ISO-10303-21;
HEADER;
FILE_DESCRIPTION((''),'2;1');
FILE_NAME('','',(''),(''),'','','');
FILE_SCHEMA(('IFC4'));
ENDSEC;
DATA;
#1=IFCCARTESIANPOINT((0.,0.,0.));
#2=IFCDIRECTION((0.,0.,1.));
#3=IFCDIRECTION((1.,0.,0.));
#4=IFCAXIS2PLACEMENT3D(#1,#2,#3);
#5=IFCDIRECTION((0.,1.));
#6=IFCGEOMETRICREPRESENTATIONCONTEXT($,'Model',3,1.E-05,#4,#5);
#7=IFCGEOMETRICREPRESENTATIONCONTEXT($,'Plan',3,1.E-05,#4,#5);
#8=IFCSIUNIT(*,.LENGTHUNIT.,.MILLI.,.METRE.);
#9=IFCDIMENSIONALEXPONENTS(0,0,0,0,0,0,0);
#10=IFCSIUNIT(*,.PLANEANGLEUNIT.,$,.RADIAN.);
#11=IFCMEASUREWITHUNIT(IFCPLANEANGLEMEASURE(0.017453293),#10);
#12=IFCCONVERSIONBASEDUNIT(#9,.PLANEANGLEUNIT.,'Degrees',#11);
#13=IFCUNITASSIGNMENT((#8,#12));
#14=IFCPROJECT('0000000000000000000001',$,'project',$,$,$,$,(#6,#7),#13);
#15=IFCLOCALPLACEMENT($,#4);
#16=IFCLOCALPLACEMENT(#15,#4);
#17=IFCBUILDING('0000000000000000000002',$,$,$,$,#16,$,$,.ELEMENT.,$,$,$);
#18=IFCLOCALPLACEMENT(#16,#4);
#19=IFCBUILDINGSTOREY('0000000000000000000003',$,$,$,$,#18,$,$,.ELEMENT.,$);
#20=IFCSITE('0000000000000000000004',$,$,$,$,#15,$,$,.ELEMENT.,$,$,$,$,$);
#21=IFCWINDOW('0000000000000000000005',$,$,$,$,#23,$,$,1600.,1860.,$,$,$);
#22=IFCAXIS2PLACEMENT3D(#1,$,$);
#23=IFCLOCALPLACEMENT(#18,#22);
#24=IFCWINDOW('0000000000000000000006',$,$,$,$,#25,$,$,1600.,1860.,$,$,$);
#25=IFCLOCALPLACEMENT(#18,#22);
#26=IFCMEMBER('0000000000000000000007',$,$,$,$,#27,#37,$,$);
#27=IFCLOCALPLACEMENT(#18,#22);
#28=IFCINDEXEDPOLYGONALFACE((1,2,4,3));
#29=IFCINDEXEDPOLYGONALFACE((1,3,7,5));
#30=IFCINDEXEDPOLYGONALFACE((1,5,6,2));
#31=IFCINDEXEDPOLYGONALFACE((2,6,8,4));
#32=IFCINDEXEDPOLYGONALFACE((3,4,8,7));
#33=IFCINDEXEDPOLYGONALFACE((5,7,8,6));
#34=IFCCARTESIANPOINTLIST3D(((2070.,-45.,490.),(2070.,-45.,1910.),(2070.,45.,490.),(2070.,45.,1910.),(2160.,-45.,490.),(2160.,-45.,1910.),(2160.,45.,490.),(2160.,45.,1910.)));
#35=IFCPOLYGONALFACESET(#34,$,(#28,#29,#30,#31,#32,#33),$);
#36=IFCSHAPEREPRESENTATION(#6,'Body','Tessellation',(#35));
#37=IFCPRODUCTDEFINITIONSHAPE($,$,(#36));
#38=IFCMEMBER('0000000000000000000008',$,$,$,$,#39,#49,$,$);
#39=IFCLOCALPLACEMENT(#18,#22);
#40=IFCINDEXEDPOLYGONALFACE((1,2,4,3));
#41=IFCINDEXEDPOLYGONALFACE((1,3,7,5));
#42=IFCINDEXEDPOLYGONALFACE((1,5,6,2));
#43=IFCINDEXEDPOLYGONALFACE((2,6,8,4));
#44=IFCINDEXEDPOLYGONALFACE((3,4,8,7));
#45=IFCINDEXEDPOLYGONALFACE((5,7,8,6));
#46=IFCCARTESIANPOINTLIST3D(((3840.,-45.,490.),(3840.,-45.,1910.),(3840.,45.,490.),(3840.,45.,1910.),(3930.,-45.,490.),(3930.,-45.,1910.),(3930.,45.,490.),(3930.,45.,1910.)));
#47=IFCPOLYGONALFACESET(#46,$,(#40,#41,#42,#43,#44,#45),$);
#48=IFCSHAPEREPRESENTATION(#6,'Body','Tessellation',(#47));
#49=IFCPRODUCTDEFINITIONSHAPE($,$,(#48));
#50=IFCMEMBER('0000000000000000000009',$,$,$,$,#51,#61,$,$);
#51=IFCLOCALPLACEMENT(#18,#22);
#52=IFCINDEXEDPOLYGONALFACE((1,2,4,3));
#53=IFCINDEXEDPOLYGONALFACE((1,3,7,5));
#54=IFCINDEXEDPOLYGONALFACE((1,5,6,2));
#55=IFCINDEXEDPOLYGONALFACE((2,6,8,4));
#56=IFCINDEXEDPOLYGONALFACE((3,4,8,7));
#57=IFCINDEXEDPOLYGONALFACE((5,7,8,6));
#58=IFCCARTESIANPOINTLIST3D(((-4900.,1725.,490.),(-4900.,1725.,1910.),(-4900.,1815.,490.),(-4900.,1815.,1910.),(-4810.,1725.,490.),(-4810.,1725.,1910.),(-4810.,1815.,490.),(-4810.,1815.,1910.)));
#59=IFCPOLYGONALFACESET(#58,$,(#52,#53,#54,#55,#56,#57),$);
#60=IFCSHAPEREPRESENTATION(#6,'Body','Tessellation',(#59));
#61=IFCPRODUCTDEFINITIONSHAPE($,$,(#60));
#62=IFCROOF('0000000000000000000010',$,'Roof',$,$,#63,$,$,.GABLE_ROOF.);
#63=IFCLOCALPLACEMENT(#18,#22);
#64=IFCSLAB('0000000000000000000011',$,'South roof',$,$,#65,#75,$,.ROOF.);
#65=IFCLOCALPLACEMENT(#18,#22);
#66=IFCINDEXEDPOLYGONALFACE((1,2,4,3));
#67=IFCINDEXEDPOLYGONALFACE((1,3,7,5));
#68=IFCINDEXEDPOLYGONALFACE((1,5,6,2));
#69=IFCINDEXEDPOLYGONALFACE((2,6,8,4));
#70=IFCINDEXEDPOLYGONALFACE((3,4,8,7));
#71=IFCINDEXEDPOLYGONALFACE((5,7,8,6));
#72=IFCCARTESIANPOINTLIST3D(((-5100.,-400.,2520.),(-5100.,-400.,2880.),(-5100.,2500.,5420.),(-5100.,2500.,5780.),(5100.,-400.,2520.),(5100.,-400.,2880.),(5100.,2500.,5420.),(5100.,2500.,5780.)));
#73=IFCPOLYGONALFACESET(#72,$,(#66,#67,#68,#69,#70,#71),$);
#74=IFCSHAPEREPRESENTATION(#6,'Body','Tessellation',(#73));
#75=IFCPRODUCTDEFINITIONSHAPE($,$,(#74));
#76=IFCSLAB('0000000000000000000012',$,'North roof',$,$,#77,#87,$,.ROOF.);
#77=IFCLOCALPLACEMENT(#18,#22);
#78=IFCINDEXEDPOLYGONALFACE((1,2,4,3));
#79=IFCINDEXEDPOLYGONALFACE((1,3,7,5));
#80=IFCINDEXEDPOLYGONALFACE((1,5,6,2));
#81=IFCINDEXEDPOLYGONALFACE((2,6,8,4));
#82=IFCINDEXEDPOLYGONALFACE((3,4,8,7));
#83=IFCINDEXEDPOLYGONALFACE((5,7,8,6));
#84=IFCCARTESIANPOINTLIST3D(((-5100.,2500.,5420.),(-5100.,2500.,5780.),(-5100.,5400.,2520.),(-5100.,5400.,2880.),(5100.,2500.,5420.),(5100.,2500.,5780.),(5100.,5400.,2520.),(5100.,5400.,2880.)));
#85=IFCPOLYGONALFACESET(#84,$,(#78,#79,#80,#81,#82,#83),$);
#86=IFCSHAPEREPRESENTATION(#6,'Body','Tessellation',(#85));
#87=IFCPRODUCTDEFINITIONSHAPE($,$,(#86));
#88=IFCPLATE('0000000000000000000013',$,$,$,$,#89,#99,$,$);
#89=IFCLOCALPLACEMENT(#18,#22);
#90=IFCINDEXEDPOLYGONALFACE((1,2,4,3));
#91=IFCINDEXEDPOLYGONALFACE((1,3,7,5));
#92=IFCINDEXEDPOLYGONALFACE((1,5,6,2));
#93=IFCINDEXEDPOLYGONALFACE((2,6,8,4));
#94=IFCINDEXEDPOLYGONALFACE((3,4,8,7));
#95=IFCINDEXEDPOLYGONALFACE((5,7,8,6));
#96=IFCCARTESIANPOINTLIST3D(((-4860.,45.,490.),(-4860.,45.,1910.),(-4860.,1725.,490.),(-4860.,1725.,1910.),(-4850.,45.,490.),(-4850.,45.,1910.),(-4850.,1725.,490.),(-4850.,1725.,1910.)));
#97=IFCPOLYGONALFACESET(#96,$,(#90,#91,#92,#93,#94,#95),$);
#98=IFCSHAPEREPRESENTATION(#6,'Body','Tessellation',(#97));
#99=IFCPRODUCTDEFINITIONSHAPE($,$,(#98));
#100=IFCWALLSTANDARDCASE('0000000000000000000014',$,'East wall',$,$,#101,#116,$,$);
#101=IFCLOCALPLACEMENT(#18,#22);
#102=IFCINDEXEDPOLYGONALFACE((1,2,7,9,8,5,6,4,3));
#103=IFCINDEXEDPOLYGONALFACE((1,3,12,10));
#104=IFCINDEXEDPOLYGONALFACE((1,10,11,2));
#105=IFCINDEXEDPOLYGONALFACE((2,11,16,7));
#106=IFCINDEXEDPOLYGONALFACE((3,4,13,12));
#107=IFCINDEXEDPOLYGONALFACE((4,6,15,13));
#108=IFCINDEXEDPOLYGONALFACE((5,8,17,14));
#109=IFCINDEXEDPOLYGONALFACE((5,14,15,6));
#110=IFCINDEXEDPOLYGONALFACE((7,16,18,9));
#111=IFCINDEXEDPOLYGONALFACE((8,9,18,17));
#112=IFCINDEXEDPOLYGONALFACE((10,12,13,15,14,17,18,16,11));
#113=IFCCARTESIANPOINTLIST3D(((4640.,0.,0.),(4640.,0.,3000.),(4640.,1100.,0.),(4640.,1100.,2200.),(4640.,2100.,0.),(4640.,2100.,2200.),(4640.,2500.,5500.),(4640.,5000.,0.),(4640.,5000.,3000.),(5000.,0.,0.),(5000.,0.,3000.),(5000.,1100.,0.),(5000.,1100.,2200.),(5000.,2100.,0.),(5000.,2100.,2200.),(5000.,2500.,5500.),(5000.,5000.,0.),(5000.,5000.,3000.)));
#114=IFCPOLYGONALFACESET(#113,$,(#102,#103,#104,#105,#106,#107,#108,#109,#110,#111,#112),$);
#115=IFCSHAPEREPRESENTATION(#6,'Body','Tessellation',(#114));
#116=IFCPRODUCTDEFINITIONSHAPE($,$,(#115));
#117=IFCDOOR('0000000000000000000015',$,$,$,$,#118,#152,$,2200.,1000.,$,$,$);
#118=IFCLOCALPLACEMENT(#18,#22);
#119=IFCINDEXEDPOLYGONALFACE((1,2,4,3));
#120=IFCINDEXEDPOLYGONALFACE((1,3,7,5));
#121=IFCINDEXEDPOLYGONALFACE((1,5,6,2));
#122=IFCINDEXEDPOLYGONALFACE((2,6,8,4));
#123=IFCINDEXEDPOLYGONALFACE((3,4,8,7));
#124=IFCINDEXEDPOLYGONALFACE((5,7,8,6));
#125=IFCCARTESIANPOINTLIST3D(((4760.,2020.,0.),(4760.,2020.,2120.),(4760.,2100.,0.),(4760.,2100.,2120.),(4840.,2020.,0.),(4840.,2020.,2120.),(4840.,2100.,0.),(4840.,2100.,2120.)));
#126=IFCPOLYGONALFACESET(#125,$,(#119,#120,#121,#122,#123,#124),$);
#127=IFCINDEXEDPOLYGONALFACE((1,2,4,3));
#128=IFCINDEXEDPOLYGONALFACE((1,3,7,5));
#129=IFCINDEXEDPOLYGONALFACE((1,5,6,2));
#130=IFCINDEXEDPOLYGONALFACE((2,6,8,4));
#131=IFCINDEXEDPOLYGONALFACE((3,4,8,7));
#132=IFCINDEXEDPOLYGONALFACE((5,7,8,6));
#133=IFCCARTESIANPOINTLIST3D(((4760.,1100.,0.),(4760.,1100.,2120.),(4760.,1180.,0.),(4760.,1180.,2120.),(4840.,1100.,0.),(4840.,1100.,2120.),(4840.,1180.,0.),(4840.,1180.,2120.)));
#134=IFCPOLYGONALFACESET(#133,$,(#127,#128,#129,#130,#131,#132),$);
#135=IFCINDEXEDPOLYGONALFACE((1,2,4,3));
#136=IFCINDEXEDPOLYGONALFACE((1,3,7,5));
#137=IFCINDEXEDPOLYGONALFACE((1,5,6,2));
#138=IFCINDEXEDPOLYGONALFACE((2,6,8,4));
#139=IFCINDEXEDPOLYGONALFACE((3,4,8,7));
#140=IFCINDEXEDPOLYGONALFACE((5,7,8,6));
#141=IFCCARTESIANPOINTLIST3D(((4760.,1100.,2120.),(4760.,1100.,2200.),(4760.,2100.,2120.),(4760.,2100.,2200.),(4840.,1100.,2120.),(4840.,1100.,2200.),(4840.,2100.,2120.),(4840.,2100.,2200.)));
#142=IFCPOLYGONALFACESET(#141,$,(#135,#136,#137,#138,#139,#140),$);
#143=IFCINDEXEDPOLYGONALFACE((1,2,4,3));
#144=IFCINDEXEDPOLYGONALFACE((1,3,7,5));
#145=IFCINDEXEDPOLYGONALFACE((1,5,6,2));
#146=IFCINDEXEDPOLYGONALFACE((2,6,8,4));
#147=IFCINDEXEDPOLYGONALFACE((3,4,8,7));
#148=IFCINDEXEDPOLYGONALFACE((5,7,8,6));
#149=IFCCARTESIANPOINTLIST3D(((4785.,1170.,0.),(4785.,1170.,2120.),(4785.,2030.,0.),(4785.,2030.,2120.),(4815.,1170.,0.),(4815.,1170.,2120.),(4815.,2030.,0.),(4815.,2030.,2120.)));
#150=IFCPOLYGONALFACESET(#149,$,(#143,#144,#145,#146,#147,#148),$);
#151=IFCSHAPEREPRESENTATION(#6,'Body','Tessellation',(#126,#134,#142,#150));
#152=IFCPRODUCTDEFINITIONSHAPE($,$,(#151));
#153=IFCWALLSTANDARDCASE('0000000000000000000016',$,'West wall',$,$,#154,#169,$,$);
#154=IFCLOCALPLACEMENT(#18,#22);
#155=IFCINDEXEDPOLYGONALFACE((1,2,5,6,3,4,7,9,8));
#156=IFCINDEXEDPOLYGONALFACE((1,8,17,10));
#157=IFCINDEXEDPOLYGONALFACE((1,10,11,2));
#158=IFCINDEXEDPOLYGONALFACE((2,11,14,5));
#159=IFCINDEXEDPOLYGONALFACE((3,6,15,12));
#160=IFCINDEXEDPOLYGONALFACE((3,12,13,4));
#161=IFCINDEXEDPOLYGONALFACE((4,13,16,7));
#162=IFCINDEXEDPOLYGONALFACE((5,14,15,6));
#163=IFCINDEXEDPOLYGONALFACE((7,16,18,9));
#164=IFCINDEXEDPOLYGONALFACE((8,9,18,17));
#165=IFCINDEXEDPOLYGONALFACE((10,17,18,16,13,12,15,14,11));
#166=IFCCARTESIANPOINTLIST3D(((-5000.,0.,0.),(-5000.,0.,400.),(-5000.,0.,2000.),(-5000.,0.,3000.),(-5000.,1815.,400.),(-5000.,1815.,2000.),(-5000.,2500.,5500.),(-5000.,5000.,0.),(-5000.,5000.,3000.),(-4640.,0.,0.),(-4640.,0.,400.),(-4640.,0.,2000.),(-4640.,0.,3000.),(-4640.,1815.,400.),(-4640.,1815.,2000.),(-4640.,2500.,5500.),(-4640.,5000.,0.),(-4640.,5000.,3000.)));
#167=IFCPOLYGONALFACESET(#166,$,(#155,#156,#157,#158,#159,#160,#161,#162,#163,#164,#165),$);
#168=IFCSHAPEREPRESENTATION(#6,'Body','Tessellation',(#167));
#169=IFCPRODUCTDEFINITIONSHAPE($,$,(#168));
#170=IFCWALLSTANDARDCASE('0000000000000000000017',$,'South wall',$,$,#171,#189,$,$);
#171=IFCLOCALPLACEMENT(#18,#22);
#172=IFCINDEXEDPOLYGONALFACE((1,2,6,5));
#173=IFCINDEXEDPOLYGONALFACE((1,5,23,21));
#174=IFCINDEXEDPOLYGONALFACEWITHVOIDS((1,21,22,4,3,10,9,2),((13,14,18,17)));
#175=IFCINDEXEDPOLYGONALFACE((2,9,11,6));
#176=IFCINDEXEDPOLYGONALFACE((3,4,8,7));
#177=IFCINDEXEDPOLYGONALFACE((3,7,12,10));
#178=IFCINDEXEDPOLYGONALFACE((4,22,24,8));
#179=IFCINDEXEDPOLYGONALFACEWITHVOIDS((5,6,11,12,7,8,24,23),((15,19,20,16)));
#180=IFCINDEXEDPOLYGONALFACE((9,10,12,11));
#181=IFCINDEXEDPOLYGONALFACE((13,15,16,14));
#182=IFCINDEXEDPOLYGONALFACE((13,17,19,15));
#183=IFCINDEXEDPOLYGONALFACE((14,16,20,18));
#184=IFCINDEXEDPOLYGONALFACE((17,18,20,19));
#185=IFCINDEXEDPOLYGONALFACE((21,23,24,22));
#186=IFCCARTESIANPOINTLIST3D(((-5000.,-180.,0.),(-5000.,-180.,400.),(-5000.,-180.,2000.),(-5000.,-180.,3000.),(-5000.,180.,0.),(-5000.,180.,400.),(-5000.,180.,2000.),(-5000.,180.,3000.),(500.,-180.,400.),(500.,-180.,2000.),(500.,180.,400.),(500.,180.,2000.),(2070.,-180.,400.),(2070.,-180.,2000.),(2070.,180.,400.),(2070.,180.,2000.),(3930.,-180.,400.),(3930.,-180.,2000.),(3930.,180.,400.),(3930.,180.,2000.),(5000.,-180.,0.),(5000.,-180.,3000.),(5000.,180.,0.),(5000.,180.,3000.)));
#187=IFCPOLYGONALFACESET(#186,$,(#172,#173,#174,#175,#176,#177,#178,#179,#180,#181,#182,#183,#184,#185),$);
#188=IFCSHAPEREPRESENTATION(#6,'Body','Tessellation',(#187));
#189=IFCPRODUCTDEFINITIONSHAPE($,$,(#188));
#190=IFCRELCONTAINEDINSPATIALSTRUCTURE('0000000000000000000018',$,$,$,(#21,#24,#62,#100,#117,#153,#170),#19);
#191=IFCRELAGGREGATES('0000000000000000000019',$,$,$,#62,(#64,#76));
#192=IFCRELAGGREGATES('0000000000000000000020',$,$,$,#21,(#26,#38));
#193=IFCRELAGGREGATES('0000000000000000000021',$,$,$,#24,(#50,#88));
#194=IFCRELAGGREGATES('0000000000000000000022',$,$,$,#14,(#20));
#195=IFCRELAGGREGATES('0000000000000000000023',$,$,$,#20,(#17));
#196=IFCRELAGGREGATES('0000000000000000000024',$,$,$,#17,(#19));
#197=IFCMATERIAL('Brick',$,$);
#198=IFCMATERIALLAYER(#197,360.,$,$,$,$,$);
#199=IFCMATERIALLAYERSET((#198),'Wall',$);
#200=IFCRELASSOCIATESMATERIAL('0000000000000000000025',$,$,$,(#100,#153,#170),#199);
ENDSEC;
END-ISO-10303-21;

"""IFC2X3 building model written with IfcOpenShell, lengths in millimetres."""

from ifc_helpers import new_model, entity, si_unit, converted_unit, direction, frame, origin_with_axes, place, context, project, spatial, polyline, outline, extrude, clip, halfspace, source, transform, mapped, material, layer, layer_set, layer_usage, element, fill, aggregate, save


model = new_model("IFC2X3")

# Units and contexts
model_context = context("Model", 3, precision=1e-05, world=origin_with_axes(), true_north=direction((0.0, 1.0)))
plan_context = context("Plan", 3, precision=1e-05, world=origin_with_axes(), true_north=direction((0.0, 1.0)))
ifc_project = project(units=[si_unit("LENGTHUNIT", "METRE", prefix="MILLI"), converted_unit("PLANEANGLEUNIT", "Degrees", entity("IfcPlaneAngleMeasure", 0.017453293), si_unit("PLANEANGLEUNIT", "RADIAN"), dimensions=[0, 0, 0, 0, 0, 0, 0])], contexts=[model_context, plan_context])

# Site, building, storey
site_placement = place(None, origin_with_axes())
site = spatial("IfcSite", under=ifc_project, at=site_placement, CompositionType="ELEMENT")
building_placement = place(site_placement, origin_with_axes())
building = spatial("IfcBuilding", under=site, at=building_placement, CompositionType="ELEMENT")
storey_placement = place(building_placement, origin_with_axes())
storey = spatial("IfcBuildingStorey", under=building, at=storey_placement, CompositionType="ELEMENT")

# Windows
window_1_placement = place(storey_placement, frame((2070.0, -45.0, 400.0), z_axis=(0.0, 0.0, 1.0), x_axis=(1.0, 0.0, 0.0)))
window_1 = element("IfcWindow", 1, at=window_1_placement, inside=storey, OverallHeight=1600.0, OverallWidth=1860.0)
window_2_placement = place(storey_placement, frame((-4810.0, -45.0, 400.0), z_axis=(0.0, 0.0, 1.0), x_axis=(0.0, 1.0, 0.0)))
window_2 = element("IfcWindow", 2, at=window_2_placement, inside=storey, OverallHeight=1600.0, OverallWidth=1860.0)

# Members
shared_shape_1 = source(origin_with_axes(), model_context, "Body", "SweptSolid", [
    extrude(outline(polyline([(-45.0, -45.0), (45.0, -45.0), (45.0, 45.0), (-45.0, 45.0), (-45.0, -45.0)])), origin_with_axes(), (0.0, 0.0, 1.0), 1420.0),
])
member_1_placement = place(window_1_placement, frame((45.0, 45.0, 90.0), z_axis=(0.0, 0.0, 1.0), x_axis=(1.0, 0.0, 0.0)))
member_1 = element("IfcMember", 3, at=member_1_placement, context=model_context, shape_type="MappedRepresentation", body=[
    mapped(shared_shape_1, transform((0.0, 0.0, 0.0))),
])
member_2_placement = place(window_1_placement, frame((1815.0, 45.0, 90.0), z_axis=(0.0, 0.0, 1.0), x_axis=(1.0, 0.0, 0.0)))
member_2 = element("IfcMember", 4, at=member_2_placement, context=model_context, shape_type="MappedRepresentation", body=[
    mapped(shared_shape_1, transform((0.0, 0.0, 0.0))),
])
member_3_placement = place(window_2_placement, frame((1815.0, 45.0, 90.0), z_axis=(0.0, 0.0, 1.0), x_axis=(1.0, 0.0, 0.0)))
member_3 = element("IfcMember", 5, at=member_3_placement, context=model_context, shape_type="MappedRepresentation", body=[
    mapped(shared_shape_1, transform((0.0, 0.0, 0.0))),
])

# Roof, slabs
roof_placement = place(storey_placement, origin_with_axes())
roof = element("IfcRoof", 6, at=roof_placement, inside=storey, Name="Roof", ShapeType="GABLE_ROOF")
shared_shape_2 = source(origin_with_axes(), model_context, "Body", "SweptSolid", [
    extrude(outline(polyline([(-5100.0, -180.0), (5100.0, -180.0), (5100.0, 180.0), (-5100.0, 180.0), (-5100.0, -180.0)])), frame((0.0, 0.0, 0.0), z_axis=(0.0, 1.0, 0.0), x_axis=(1.0, 0.0, 0.0)), (0.0, -0.707107, 0.707107), 4101.2),
])
slab_1_placement = place(roof_placement, frame((0.0, -400.0, 2700.0), z_axis=(0.0, 0.0, 1.0), x_axis=(1.0, 0.0, 0.0)))
slab_1 = element("IfcSlab", 7, at=slab_1_placement, Name="South roof", PredefinedType="ROOF", context=model_context, shape_type="MappedRepresentation", body=[
    mapped(shared_shape_2, transform((0.0, 0.0, 0.0))),
])
slab_2_placement = place(roof_placement, frame((0.0, 5400.0, 2700.0), z_axis=(0.0, 0.0, 1.0), x_axis=(-1.0, 0.0, 0.0)))
slab_2 = element("IfcSlab", 8, at=slab_2_placement, Name="North roof", PredefinedType="ROOF", context=model_context, shape_type="MappedRepresentation", body=[
    mapped(shared_shape_2, transform((0.0, 0.0, 0.0))),
])
aggregate(roof, [slab_1, slab_2])

# Plate
aggregate(window_1, [member_1, member_2])
plate_1_placement = place(window_2_placement, frame((930.0, 45.0, 90.0), z_axis=(0.0, 0.0, 1.0), x_axis=(1.0, 0.0, 0.0)))
plate_1 = element("IfcPlate", 9, at=plate_1_placement, context=model_context, shape_type="SweptSolid", body=[
    extrude(outline(polyline([(-840.0, -5.0), (840.0, -5.0), (840.0, 5.0), (-840.0, 5.0), (-840.0, -5.0)])), origin_with_axes(), (0.0, 0.0, 1.0), 1420.0),
])
aggregate(window_2, [member_3, plate_1])

# Wall, opening, door
ifc_material = material(Name="Brick")
ifc_layer = layer(ifc_material, 360.0)
ifc_layer_set = layer_set([ifc_layer], Name="Wall")
ifc_layer_usage = layer_usage(ifc_layer_set, "AXIS2", "POSITIVE", -180.0)
shared_shape_3 = source(origin_with_axes(), model_context, "Body", "Clipping", [
    clip(clip(extrude(outline(polyline([(-2500.0, -180.0), (2500.0, -180.0), (2500.0, 180.0), (-2500.0, 180.0), (-2500.0, -180.0)])), origin_with_axes(), (0.0, 0.0, 1.0), 6000.0), halfspace(frame((-2500.0, 0.0, 3000.0), z_axis=(-1.0, 0.0, 1.0), x_axis=(1.0, 0.0, 0.0)), False)), halfspace(frame((2500.0, 0.0, 3000.0), z_axis=(1.0, 0.0, 1.0), x_axis=(1.0, 0.0, 0.0)), False)),
])
wall_1_placement = place(storey_placement, frame((4820.0, 2500.0, 0.0), z_axis=(0.0, 0.0, 1.0), x_axis=(0.0, 1.0, 0.0)))
wall_1 = element("IfcWallStandardCase", 10, at=wall_1_placement, inside=storey, material=ifc_layer_usage, Name="East wall", context=model_context, shape_type="MappedRepresentation", body=[
    mapped(shared_shape_3, transform((0.0, 0.0, 0.0))),
])
opening_1_placement = place(storey_placement, frame((4820.0, 1600.0, 0.0), z_axis=(0.0, 0.0, 1.0), x_axis=(1.0, 0.0, 0.0)))
opening_1 = element("IfcOpeningElement", 11, at=opening_1_placement, cuts=wall_1, context=model_context, shape_type="SweptSolid", body=[
    extrude(outline(polyline([(-500.0, -500.0), (500.0, -500.0), (500.0, 500.0), (-500.0, 500.0), (-500.0, -500.0)])), origin_with_axes(), (0.0, 0.0, 1.0), 2200.0),
])
door_placement = place(storey_placement, frame((4800.0, 1600.0, 0.0), z_axis=(0.0, 0.0, 1.0), x_axis=(0.0, 1.0, 0.0)))
door = element("IfcDoor", 12, at=door_placement, inside=storey, OverallHeight=2200.0, OverallWidth=1000.0, context=model_context, shape_type="SweptSolid", body=[
    extrude(outline(polyline([(-40.0, -40.0), (40.0, -40.0), (40.0, 40.0), (-40.0, 40.0), (-40.0, -40.0)])), frame((460.0, 0.0, 0.0), z_axis=(0.0, 0.0, 1.0), x_axis=(1.0, 0.0, 0.0)), (0.0, 0.0, 1.0), 2120.0),
    extrude(outline(polyline([(-40.0, -40.0), (40.0, -40.0), (40.0, 40.0), (-40.0, 40.0), (-40.0, -40.0)])), frame((-460.0, 0.0, 0.0), z_axis=(0.0, 0.0, 1.0), x_axis=(1.0, 0.0, 0.0)), (0.0, 0.0, 1.0), 2120.0),
    extrude(outline(polyline([(-500.0, -40.0), (500.0, -40.0), (500.0, 40.0), (-500.0, 40.0), (-500.0, -40.0)])), frame((0.0, 0.0, 2120.0), z_axis=(0.0, 0.0, 1.0), x_axis=(1.0, 0.0, 0.0)), (0.0, 0.0, 1.0), 80.0),
    extrude(outline(polyline([(-430.0, -15.0), (430.0, -15.0), (430.0, 15.0), (-430.0, 15.0), (-430.0, -15.0)])), origin_with_axes(), (0.0, 0.0, 1.0), 2120.0),
])
fill(opening_1, door)

# Wall, opening
wall_2_placement = place(storey_placement, frame((-4820.0, 2500.0, 0.0), z_axis=(0.0, 0.0, 1.0), x_axis=(0.0, -1.0, 0.0)))
wall_2 = element("IfcWallStandardCase", 13, at=wall_2_placement, inside=storey, material=ifc_layer_usage, Name="West wall", context=model_context, shape_type="MappedRepresentation", body=[
    mapped(shared_shape_3, transform((0.0, 0.0, 0.0))),
])
opening_2_placement = place(wall_2_placement, frame((2500.0, 2320.0, 400.0), z_axis=(0.0, 0.0, 1.0), x_axis=(0.0, 1.0, 0.0)))
element("IfcOpeningElement", 14, at=opening_2_placement, cuts=wall_2, context=model_context, shape_type="SweptSolid", body=[
    extrude(outline(polyline([(-3000.0, -1815.0), (3000.0, -1815.0), (3000.0, 1815.0), (-3000.0, 1815.0), (-3000.0, -1815.0)])), origin_with_axes(), (0.0, 0.0, 1.0), 1600.0),
])

# Wall, openings
wall_3_placement = place(storey_placement, origin_with_axes())
wall_3 = element("IfcWallStandardCase", 15, at=wall_3_placement, inside=storey, material=ifc_layer_usage, Name="South wall", context=model_context, shape_type="SweptSolid", body=[
    extrude(outline(polyline([(-5000.0, -180.0), (5000.0, -180.0), (5000.0, 180.0), (-5000.0, 180.0), (-5000.0, -180.0)])), origin_with_axes(), (0.0, 0.0, 1.0), 3000.0),
])
opening_3_placement = place(wall_3_placement, frame((-2500.0, 0.0, 400.0), z_axis=(0.0, 0.0, 1.0), x_axis=(1.0, 0.0, 0.0)))
element("IfcOpeningElement", 16, at=opening_3_placement, cuts=wall_3, context=model_context, shape_type="SweptSolid", body=[
    extrude(outline(polyline([(-3000.0, -1815.0), (3000.0, -1815.0), (3000.0, 1815.0), (-3000.0, 1815.0), (-3000.0, -1815.0)])), origin_with_axes(), (0.0, 0.0, 1.0), 1600.0),
])
opening_4_placement = place(storey_placement, frame((3000.0, 0.0, 400.0), z_axis=(0.0, 0.0, 1.0), x_axis=(1.0, 0.0, 0.0)))
element("IfcOpeningElement", 17, at=opening_4_placement, cuts=wall_3, context=model_context, shape_type="SweptSolid", body=[
    extrude(outline(polyline([(-930.0, -1500.0), (930.0, -1500.0), (930.0, 1500.0), (-930.0, 1500.0), (-930.0, -1500.0)])), origin_with_axes(), (0.0, 0.0, 1.0), 1600.0),
])

save(model, "model.ifc")
